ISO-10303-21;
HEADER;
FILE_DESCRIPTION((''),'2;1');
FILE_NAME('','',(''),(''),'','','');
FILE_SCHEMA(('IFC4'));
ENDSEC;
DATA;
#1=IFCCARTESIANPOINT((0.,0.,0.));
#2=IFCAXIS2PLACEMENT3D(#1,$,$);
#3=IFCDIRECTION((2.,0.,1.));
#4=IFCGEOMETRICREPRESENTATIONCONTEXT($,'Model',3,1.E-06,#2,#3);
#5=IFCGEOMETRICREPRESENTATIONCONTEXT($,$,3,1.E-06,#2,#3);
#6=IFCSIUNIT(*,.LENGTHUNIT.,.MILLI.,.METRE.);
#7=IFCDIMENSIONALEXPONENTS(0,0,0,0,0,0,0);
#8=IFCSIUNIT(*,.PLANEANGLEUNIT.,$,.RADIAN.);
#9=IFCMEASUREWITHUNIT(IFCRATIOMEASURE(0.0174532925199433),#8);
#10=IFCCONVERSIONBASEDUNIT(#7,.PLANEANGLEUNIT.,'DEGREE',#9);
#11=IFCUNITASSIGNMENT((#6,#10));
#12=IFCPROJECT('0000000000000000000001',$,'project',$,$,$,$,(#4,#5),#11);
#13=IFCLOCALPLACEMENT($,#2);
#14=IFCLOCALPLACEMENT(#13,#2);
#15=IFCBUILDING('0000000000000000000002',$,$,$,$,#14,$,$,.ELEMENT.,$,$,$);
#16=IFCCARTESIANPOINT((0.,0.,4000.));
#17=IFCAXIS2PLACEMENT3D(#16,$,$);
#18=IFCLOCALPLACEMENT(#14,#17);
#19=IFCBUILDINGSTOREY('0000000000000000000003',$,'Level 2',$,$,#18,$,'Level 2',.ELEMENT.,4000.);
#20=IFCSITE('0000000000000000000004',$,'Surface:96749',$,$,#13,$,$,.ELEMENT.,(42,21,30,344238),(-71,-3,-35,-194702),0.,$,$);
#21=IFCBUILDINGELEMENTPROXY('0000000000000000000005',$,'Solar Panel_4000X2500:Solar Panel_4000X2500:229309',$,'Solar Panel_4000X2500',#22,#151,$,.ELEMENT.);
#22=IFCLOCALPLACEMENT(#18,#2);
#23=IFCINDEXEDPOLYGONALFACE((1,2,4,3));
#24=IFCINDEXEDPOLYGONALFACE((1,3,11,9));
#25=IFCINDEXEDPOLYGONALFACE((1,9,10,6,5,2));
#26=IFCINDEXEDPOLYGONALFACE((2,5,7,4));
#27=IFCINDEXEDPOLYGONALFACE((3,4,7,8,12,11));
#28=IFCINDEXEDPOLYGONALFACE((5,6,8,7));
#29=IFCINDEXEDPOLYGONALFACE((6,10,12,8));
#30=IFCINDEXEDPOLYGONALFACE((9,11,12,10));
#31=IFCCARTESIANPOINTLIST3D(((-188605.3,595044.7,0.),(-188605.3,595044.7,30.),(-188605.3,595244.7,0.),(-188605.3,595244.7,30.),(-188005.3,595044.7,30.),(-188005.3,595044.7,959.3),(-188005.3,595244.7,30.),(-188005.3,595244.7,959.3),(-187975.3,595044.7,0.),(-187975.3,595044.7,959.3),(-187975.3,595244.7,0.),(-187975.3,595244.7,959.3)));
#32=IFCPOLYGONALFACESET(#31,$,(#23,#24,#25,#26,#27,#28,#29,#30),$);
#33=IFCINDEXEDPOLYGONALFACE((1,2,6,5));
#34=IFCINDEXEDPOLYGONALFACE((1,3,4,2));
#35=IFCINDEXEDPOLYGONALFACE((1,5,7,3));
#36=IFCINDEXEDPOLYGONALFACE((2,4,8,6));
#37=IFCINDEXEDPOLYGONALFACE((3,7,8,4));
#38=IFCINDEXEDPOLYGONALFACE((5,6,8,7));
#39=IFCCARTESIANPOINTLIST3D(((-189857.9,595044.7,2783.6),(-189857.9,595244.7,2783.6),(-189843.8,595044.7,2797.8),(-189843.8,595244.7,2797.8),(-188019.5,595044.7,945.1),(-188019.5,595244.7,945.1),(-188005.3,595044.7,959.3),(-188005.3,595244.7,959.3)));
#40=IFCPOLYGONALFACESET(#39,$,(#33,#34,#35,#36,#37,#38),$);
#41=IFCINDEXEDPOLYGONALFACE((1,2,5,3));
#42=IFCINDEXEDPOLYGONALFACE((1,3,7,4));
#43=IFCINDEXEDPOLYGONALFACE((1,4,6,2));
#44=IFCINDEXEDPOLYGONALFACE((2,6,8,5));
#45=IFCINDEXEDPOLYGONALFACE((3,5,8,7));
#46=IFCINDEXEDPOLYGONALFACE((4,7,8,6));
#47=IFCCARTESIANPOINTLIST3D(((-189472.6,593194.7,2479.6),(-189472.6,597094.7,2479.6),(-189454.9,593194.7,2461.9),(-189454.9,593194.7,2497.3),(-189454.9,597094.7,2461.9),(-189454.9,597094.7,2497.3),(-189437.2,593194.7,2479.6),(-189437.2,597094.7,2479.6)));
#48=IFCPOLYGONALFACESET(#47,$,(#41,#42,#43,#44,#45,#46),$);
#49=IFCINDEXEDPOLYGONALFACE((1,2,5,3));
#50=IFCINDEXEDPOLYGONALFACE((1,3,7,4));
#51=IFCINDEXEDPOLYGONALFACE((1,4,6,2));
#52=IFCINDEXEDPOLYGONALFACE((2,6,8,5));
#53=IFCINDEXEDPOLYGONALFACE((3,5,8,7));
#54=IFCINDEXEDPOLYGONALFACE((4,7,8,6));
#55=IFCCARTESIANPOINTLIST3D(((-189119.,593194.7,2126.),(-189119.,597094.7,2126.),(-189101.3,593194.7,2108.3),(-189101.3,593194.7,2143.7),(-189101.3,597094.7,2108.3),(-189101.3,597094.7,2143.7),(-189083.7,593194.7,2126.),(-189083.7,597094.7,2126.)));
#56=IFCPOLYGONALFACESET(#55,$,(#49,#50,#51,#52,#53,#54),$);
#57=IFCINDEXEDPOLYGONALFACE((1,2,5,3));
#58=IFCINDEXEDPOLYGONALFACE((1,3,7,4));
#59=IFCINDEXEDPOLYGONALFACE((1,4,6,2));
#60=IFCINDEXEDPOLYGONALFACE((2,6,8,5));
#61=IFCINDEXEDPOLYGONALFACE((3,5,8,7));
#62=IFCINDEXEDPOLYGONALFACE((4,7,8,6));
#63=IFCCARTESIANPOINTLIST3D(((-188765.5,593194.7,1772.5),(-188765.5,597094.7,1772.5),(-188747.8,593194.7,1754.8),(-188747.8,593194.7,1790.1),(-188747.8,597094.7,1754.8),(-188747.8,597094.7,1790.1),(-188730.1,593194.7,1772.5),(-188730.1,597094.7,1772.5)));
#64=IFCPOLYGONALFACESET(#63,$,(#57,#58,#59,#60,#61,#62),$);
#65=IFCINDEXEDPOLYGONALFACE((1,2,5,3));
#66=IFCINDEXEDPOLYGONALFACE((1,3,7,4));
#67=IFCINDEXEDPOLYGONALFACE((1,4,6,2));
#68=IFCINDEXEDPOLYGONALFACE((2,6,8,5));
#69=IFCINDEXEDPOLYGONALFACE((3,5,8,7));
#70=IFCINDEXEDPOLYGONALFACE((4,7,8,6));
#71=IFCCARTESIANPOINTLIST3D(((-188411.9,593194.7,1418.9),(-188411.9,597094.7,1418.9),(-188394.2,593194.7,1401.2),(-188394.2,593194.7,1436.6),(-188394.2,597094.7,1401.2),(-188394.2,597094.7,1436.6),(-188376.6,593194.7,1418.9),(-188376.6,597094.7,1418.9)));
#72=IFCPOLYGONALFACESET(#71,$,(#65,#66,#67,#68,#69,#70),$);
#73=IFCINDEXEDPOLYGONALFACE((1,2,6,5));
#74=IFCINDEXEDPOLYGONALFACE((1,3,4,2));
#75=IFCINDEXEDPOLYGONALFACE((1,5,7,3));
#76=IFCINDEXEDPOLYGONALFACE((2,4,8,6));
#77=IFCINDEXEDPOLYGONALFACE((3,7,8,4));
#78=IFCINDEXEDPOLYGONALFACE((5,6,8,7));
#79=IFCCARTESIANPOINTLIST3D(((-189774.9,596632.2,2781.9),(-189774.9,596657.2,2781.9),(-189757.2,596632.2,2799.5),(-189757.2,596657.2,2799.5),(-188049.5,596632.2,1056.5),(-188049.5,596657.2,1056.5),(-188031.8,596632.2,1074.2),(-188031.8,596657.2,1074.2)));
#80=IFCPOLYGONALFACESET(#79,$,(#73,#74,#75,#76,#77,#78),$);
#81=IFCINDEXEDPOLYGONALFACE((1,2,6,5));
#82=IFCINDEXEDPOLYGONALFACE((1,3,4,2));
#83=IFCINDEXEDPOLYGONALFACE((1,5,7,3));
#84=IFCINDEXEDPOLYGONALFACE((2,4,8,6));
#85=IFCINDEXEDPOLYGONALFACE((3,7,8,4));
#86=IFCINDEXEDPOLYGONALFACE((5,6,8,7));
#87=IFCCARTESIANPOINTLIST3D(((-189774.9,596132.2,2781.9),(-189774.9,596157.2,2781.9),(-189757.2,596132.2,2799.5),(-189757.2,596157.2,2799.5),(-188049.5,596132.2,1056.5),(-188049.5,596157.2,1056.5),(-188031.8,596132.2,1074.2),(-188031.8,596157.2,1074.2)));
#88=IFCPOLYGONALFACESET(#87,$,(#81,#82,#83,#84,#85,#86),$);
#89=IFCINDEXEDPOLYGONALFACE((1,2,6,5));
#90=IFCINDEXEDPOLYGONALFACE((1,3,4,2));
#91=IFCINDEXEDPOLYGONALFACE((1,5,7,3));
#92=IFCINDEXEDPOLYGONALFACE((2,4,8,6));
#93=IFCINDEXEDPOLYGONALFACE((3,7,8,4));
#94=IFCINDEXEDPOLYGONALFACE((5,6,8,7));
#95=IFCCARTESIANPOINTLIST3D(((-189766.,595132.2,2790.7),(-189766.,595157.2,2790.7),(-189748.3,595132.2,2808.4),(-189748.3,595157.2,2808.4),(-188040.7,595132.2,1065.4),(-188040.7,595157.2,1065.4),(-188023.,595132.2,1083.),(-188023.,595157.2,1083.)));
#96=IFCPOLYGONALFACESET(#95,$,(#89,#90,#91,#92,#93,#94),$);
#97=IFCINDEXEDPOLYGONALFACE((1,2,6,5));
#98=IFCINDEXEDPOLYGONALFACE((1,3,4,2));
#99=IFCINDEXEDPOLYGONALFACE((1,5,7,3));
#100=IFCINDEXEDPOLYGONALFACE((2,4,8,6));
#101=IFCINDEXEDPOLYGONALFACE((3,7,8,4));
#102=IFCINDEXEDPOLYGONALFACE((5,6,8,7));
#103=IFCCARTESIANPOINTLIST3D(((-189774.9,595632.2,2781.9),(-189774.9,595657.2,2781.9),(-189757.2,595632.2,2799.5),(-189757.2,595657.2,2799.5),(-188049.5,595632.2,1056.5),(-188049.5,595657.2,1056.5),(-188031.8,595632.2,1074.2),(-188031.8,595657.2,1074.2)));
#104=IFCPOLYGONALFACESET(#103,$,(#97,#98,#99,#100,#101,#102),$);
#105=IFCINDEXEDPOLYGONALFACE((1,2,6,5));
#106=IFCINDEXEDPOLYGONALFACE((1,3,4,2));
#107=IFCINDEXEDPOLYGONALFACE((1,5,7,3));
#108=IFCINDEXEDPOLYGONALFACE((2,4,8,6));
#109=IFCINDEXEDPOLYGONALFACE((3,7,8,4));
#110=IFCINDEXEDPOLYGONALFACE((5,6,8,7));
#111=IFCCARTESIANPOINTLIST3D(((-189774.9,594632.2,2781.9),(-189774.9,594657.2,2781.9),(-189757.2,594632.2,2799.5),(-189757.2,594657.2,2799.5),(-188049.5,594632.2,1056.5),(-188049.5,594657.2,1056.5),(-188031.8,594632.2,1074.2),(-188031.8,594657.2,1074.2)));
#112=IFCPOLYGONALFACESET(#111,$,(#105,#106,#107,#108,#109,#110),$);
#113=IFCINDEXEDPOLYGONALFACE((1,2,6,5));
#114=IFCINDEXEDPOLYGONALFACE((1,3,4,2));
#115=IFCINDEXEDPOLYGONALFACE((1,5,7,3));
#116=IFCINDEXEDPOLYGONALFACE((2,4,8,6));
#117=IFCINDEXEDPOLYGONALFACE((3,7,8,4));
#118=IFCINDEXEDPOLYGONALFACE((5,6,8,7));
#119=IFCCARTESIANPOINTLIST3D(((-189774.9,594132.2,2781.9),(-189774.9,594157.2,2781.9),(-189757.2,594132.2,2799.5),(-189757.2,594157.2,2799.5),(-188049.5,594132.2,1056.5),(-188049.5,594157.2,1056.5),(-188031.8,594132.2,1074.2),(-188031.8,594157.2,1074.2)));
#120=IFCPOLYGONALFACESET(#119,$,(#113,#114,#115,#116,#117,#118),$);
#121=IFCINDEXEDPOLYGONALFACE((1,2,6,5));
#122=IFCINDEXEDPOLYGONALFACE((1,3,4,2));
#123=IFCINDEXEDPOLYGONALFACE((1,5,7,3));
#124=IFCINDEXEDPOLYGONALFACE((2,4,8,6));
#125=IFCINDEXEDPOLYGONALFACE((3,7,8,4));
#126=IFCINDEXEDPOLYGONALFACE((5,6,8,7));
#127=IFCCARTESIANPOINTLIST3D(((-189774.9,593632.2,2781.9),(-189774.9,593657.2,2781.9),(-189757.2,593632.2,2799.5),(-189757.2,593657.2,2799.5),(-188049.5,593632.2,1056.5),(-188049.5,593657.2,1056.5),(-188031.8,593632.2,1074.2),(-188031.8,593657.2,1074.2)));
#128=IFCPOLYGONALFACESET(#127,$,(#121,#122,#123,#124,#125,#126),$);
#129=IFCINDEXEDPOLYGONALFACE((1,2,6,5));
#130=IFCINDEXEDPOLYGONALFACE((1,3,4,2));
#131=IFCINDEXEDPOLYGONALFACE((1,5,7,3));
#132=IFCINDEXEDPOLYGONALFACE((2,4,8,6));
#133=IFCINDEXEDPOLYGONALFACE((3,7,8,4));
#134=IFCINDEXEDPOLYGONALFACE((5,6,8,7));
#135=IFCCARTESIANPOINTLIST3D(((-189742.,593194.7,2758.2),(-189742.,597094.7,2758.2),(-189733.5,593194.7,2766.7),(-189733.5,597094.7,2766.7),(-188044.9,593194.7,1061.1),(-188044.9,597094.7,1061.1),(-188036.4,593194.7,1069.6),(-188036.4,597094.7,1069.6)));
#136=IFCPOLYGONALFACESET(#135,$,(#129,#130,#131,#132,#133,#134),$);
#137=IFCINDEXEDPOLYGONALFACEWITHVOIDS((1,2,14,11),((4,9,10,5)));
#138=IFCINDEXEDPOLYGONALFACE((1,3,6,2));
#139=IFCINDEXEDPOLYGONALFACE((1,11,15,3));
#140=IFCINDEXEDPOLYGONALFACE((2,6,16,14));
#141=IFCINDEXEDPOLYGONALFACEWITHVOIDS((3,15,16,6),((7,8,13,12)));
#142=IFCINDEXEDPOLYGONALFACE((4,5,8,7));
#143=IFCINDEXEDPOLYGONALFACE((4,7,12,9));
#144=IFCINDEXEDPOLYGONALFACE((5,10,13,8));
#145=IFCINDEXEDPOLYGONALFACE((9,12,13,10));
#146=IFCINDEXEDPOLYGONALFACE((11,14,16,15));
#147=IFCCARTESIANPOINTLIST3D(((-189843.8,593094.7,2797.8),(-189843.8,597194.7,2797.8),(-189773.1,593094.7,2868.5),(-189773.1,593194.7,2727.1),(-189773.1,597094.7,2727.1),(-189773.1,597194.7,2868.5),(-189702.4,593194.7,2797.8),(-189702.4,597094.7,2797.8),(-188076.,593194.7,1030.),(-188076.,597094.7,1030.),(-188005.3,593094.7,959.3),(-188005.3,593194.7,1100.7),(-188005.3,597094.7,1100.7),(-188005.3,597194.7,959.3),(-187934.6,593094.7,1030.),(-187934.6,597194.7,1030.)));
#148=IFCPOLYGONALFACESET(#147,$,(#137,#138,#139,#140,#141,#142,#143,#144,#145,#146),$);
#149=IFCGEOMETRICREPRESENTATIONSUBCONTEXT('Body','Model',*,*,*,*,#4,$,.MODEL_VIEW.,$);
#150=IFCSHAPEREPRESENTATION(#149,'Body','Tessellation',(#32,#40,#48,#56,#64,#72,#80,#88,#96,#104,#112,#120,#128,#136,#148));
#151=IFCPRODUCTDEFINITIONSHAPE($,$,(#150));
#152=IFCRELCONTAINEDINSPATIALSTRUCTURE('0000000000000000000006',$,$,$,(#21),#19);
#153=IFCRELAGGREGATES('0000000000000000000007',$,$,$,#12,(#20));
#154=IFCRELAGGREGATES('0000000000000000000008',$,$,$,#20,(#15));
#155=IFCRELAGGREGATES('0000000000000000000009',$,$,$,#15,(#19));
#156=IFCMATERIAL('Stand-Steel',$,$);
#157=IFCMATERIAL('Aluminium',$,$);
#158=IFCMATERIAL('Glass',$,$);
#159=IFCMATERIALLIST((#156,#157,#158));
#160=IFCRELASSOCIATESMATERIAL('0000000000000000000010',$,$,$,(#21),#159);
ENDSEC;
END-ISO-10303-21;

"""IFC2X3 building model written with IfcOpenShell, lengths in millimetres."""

from ifc_helpers import new_model, entity, si_unit, converted_unit, direction, frame, frame_2d, origin, origin_2d_with_axis, place, context, subcontext, project, spatial, polyline, rectangle, outline, extrude, source, transform, mapped, material, material_list, element, save


model = new_model("IFC2X3")

# Units and contexts
model_context = context("Model", 3, precision=1e-06, world=origin(), true_north=direction((2.0, 0.0, 1.0)))
context_of_model = context(None, 3, precision=1e-06, world=origin(), true_north=direction((2.0, 0.0, 1.0)))
body_context = subcontext(model_context, "Body", "Model", "MODEL_VIEW")
ifc_project = project(units=[si_unit("LENGTHUNIT", "METRE", prefix="MILLI"), converted_unit("PLANEANGLEUNIT", "DEGREE", entity("IfcRatioMeasure", 0.0174532925199433), si_unit("PLANEANGLEUNIT", "RADIAN"), dimensions=[0, 0, 0, 0, 0, 0, 0])], contexts=[model_context, context_of_model])

# Site, building, storey
site_placement = place(None, origin())
site = spatial("IfcSite", under=ifc_project, at=site_placement, Name="Surface:96749", CompositionType="ELEMENT", RefLatitude=(42, 21, 30, 344238), RefLongitude=(-71, -3, -35, -194702), RefElevation=0.0)
building_placement = place(site_placement, origin())
building = spatial("IfcBuilding", under=site, at=building_placement, CompositionType="ELEMENT")
storey_placement = place(building_placement, frame((0.0, 0.0, 4000.0)))
storey = spatial("IfcBuildingStorey", under=building, at=storey_placement, Name="Level 2", LongName="Level 2", CompositionType="ELEMENT", Elevation=4000.0)

# Building element proxy
ifc_material_1 = material(Name="Stand-Steel")
ifc_material_2 = material(Name="Aluminium")
ifc_material_3 = material(Name="Glass")
shared_shape = source(origin(), body_context, "Body", "SweptSolid", [
    extrude(outline(polyline([(-629.5, -220.0), (329.8, -220.0), (329.8, 410.0), (299.8, 410.0), (299.8, -190.0), (-629.5, -190.0), (-629.5, -220.0)])), frame((-190.0, -100.0, 299.8), z_axis=(0.0, 1.0, 0.0), x_axis=(0.0, 0.0, -1.0)), (0.0, 0.0, 1.0), 200.0),
    extrude(rectangle(XDim=20.0, YDim=200.0, at=frame_2d((0.0, 0.0), x_axis=(0.0, 1.0))), frame((-7.1, 0.0, 922.2), z_axis=(-0.707107, 0.0, 0.707107), x_axis=(0.0, 1.0, 0.0)), (0.0, 0.0, 1.0), 2600.0),
    extrude(rectangle(XDim=25.0, YDim=25.0, at=frame_2d((0.0, 0.0), x_axis=(1.0, 0.0))), frame((-1449.6, -1950.0, 2449.6), z_axis=(0.0, 1.0, 0.0), x_axis=(-0.707107, 0.0, -0.707107)), (0.0, 0.0, 1.0), 3900.0),
    extrude(rectangle(XDim=25.0, YDim=25.0, at=origin_2d_with_axis()), frame((-1096.0, -1950.0, 2096.0), z_axis=(0.0, 1.0, 0.0), x_axis=(-0.707107, 0.0, -0.707107)), (0.0, 0.0, 1.0), 3900.0),
    extrude(rectangle(XDim=25.0, YDim=25.0, at=origin_2d_with_axis()), frame((-742.5, -1950.0, 1742.5), z_axis=(0.0, 1.0, 0.0), x_axis=(-0.707107, 0.0, -0.707107)), (0.0, 0.0, 1.0), 3900.0),
    extrude(rectangle(XDim=25.0, YDim=25.0, at=frame_2d((0.0, 0.0), x_axis=(1.0, 0.0))), frame((-388.9, -1950.0, 1388.9), z_axis=(0.0, 1.0, 0.0), x_axis=(-0.707107, 0.0, -0.707107)), (0.0, 0.0, 1.0), 3900.0),
    extrude(rectangle(XDim=25.0, YDim=25.0, at=frame_2d((0.0, 0.0), x_axis=(0.0, 1.0))), frame((-35.4, 1500.0, 1035.4), z_axis=(-0.707107, 0.0, 0.707107), x_axis=(0.0, 1.0, 0.0)), (0.0, 0.0, 1.0), 2440.0),
    extrude(rectangle(XDim=25.0, YDim=25.0, at=frame_2d((0.0, 0.0), x_axis=(0.0, 1.0))), frame((-35.4, 1000.0, 1035.4), z_axis=(-0.707107, 0.0, 0.707107), x_axis=(0.0, 1.0, 0.0)), (0.0, 0.0, 1.0), 2440.0),
    extrude(rectangle(XDim=25.0, YDim=25.0, at=frame_2d((0.0, 0.0), x_axis=(0.0, 1.0))), frame((-26.5, 0.0, 1044.2), z_axis=(-0.707107, 0.0, 0.707107), x_axis=(0.0, -1.0, 0.0)), (0.0, 0.0, 1.0), 2440.0),
    extrude(rectangle(XDim=25.0, YDim=25.0, at=frame_2d((0.0, 0.0), x_axis=(0.0, 1.0))), frame((-35.4, 500.0, 1035.4), z_axis=(-0.707107, 0.0, 0.707107), x_axis=(0.0, 1.0, 0.0)), (0.0, 0.0, 1.0), 2440.0),
    extrude(rectangle(XDim=25.0, YDim=25.0, at=frame_2d((0.0, 0.0), x_axis=(0.0, 1.0))), frame((-35.4, -500.0, 1035.4), z_axis=(-0.707107, 0.0, 0.707107), x_axis=(0.0, 1.0, 0.0)), (0.0, 0.0, 1.0), 2440.0),
    extrude(rectangle(XDim=25.0, YDim=25.0, at=frame_2d((0.0, 0.0), x_axis=(0.0, 1.0))), frame((-35.4, -1000.0, 1035.4), z_axis=(-0.707107, 0.0, 0.707107), x_axis=(0.0, 1.0, 0.0)), (0.0, 0.0, 1.0), 2440.0),
    extrude(rectangle(XDim=25.0, YDim=25.0, at=frame_2d((0.0, 0.0), x_axis=(0.0, 1.0))), frame((-35.4, -1500.0, 1035.4), z_axis=(-0.707107, 0.0, 0.707107), x_axis=(0.0, 1.0, 0.0)), (0.0, 0.0, 1.0), 2440.0),
    extrude(rectangle(XDim=2400.0, YDim=12.0, at=frame_2d((0.0, 0.0), x_axis=(1.0, 0.0))), frame((-883.9, -1950.0, 1883.9), z_axis=(0.0, 1.0, 0.0), x_axis=(0.707107, 0.0, -0.707107)), (0.0, 0.0, 1.0), 3900.0),
    extrude(outline(polyline([(-2050.0, -1300.0), (2050.0, -1300.0), (2050.0, 1300.0), (-2050.0, 1300.0), (-2050.0, -1300.0)]), holes=[polyline([(1950.0, -1200.0), (-1950.0, -1200.0), (-1950.0, 1200.0), (1950.0, 1200.0), (1950.0, -1200.0)])]), frame((-919.2, 0.0, 1848.5), z_axis=(0.707107, 0.0, 0.707107), x_axis=(0.0, 1.0, 0.0)), (0.0, 0.0, 1.0), 100.0),
])
ifc_material_list_1 = material_list([ifc_material_1, ifc_material_2, ifc_material_3])
proxy_1_placement = place(storey_placement, frame((-188005.3, 595144.7, 30.0)))
element("IfcBuildingElementProxy", 1, at=proxy_1_placement, inside=storey, material=ifc_material_list_1, Name="Solar Panel_4000X2500:Solar Panel_4000X2500:229309", ObjectType="Solar Panel_4000X2500", CompositionType="ELEMENT", context=body_context, shape_type="MappedRepresentation", body=[
    mapped(shared_shape, transform((0.0, 0.0, 0.0), scale=1.0)),
])

save(model, "model.ifc")
